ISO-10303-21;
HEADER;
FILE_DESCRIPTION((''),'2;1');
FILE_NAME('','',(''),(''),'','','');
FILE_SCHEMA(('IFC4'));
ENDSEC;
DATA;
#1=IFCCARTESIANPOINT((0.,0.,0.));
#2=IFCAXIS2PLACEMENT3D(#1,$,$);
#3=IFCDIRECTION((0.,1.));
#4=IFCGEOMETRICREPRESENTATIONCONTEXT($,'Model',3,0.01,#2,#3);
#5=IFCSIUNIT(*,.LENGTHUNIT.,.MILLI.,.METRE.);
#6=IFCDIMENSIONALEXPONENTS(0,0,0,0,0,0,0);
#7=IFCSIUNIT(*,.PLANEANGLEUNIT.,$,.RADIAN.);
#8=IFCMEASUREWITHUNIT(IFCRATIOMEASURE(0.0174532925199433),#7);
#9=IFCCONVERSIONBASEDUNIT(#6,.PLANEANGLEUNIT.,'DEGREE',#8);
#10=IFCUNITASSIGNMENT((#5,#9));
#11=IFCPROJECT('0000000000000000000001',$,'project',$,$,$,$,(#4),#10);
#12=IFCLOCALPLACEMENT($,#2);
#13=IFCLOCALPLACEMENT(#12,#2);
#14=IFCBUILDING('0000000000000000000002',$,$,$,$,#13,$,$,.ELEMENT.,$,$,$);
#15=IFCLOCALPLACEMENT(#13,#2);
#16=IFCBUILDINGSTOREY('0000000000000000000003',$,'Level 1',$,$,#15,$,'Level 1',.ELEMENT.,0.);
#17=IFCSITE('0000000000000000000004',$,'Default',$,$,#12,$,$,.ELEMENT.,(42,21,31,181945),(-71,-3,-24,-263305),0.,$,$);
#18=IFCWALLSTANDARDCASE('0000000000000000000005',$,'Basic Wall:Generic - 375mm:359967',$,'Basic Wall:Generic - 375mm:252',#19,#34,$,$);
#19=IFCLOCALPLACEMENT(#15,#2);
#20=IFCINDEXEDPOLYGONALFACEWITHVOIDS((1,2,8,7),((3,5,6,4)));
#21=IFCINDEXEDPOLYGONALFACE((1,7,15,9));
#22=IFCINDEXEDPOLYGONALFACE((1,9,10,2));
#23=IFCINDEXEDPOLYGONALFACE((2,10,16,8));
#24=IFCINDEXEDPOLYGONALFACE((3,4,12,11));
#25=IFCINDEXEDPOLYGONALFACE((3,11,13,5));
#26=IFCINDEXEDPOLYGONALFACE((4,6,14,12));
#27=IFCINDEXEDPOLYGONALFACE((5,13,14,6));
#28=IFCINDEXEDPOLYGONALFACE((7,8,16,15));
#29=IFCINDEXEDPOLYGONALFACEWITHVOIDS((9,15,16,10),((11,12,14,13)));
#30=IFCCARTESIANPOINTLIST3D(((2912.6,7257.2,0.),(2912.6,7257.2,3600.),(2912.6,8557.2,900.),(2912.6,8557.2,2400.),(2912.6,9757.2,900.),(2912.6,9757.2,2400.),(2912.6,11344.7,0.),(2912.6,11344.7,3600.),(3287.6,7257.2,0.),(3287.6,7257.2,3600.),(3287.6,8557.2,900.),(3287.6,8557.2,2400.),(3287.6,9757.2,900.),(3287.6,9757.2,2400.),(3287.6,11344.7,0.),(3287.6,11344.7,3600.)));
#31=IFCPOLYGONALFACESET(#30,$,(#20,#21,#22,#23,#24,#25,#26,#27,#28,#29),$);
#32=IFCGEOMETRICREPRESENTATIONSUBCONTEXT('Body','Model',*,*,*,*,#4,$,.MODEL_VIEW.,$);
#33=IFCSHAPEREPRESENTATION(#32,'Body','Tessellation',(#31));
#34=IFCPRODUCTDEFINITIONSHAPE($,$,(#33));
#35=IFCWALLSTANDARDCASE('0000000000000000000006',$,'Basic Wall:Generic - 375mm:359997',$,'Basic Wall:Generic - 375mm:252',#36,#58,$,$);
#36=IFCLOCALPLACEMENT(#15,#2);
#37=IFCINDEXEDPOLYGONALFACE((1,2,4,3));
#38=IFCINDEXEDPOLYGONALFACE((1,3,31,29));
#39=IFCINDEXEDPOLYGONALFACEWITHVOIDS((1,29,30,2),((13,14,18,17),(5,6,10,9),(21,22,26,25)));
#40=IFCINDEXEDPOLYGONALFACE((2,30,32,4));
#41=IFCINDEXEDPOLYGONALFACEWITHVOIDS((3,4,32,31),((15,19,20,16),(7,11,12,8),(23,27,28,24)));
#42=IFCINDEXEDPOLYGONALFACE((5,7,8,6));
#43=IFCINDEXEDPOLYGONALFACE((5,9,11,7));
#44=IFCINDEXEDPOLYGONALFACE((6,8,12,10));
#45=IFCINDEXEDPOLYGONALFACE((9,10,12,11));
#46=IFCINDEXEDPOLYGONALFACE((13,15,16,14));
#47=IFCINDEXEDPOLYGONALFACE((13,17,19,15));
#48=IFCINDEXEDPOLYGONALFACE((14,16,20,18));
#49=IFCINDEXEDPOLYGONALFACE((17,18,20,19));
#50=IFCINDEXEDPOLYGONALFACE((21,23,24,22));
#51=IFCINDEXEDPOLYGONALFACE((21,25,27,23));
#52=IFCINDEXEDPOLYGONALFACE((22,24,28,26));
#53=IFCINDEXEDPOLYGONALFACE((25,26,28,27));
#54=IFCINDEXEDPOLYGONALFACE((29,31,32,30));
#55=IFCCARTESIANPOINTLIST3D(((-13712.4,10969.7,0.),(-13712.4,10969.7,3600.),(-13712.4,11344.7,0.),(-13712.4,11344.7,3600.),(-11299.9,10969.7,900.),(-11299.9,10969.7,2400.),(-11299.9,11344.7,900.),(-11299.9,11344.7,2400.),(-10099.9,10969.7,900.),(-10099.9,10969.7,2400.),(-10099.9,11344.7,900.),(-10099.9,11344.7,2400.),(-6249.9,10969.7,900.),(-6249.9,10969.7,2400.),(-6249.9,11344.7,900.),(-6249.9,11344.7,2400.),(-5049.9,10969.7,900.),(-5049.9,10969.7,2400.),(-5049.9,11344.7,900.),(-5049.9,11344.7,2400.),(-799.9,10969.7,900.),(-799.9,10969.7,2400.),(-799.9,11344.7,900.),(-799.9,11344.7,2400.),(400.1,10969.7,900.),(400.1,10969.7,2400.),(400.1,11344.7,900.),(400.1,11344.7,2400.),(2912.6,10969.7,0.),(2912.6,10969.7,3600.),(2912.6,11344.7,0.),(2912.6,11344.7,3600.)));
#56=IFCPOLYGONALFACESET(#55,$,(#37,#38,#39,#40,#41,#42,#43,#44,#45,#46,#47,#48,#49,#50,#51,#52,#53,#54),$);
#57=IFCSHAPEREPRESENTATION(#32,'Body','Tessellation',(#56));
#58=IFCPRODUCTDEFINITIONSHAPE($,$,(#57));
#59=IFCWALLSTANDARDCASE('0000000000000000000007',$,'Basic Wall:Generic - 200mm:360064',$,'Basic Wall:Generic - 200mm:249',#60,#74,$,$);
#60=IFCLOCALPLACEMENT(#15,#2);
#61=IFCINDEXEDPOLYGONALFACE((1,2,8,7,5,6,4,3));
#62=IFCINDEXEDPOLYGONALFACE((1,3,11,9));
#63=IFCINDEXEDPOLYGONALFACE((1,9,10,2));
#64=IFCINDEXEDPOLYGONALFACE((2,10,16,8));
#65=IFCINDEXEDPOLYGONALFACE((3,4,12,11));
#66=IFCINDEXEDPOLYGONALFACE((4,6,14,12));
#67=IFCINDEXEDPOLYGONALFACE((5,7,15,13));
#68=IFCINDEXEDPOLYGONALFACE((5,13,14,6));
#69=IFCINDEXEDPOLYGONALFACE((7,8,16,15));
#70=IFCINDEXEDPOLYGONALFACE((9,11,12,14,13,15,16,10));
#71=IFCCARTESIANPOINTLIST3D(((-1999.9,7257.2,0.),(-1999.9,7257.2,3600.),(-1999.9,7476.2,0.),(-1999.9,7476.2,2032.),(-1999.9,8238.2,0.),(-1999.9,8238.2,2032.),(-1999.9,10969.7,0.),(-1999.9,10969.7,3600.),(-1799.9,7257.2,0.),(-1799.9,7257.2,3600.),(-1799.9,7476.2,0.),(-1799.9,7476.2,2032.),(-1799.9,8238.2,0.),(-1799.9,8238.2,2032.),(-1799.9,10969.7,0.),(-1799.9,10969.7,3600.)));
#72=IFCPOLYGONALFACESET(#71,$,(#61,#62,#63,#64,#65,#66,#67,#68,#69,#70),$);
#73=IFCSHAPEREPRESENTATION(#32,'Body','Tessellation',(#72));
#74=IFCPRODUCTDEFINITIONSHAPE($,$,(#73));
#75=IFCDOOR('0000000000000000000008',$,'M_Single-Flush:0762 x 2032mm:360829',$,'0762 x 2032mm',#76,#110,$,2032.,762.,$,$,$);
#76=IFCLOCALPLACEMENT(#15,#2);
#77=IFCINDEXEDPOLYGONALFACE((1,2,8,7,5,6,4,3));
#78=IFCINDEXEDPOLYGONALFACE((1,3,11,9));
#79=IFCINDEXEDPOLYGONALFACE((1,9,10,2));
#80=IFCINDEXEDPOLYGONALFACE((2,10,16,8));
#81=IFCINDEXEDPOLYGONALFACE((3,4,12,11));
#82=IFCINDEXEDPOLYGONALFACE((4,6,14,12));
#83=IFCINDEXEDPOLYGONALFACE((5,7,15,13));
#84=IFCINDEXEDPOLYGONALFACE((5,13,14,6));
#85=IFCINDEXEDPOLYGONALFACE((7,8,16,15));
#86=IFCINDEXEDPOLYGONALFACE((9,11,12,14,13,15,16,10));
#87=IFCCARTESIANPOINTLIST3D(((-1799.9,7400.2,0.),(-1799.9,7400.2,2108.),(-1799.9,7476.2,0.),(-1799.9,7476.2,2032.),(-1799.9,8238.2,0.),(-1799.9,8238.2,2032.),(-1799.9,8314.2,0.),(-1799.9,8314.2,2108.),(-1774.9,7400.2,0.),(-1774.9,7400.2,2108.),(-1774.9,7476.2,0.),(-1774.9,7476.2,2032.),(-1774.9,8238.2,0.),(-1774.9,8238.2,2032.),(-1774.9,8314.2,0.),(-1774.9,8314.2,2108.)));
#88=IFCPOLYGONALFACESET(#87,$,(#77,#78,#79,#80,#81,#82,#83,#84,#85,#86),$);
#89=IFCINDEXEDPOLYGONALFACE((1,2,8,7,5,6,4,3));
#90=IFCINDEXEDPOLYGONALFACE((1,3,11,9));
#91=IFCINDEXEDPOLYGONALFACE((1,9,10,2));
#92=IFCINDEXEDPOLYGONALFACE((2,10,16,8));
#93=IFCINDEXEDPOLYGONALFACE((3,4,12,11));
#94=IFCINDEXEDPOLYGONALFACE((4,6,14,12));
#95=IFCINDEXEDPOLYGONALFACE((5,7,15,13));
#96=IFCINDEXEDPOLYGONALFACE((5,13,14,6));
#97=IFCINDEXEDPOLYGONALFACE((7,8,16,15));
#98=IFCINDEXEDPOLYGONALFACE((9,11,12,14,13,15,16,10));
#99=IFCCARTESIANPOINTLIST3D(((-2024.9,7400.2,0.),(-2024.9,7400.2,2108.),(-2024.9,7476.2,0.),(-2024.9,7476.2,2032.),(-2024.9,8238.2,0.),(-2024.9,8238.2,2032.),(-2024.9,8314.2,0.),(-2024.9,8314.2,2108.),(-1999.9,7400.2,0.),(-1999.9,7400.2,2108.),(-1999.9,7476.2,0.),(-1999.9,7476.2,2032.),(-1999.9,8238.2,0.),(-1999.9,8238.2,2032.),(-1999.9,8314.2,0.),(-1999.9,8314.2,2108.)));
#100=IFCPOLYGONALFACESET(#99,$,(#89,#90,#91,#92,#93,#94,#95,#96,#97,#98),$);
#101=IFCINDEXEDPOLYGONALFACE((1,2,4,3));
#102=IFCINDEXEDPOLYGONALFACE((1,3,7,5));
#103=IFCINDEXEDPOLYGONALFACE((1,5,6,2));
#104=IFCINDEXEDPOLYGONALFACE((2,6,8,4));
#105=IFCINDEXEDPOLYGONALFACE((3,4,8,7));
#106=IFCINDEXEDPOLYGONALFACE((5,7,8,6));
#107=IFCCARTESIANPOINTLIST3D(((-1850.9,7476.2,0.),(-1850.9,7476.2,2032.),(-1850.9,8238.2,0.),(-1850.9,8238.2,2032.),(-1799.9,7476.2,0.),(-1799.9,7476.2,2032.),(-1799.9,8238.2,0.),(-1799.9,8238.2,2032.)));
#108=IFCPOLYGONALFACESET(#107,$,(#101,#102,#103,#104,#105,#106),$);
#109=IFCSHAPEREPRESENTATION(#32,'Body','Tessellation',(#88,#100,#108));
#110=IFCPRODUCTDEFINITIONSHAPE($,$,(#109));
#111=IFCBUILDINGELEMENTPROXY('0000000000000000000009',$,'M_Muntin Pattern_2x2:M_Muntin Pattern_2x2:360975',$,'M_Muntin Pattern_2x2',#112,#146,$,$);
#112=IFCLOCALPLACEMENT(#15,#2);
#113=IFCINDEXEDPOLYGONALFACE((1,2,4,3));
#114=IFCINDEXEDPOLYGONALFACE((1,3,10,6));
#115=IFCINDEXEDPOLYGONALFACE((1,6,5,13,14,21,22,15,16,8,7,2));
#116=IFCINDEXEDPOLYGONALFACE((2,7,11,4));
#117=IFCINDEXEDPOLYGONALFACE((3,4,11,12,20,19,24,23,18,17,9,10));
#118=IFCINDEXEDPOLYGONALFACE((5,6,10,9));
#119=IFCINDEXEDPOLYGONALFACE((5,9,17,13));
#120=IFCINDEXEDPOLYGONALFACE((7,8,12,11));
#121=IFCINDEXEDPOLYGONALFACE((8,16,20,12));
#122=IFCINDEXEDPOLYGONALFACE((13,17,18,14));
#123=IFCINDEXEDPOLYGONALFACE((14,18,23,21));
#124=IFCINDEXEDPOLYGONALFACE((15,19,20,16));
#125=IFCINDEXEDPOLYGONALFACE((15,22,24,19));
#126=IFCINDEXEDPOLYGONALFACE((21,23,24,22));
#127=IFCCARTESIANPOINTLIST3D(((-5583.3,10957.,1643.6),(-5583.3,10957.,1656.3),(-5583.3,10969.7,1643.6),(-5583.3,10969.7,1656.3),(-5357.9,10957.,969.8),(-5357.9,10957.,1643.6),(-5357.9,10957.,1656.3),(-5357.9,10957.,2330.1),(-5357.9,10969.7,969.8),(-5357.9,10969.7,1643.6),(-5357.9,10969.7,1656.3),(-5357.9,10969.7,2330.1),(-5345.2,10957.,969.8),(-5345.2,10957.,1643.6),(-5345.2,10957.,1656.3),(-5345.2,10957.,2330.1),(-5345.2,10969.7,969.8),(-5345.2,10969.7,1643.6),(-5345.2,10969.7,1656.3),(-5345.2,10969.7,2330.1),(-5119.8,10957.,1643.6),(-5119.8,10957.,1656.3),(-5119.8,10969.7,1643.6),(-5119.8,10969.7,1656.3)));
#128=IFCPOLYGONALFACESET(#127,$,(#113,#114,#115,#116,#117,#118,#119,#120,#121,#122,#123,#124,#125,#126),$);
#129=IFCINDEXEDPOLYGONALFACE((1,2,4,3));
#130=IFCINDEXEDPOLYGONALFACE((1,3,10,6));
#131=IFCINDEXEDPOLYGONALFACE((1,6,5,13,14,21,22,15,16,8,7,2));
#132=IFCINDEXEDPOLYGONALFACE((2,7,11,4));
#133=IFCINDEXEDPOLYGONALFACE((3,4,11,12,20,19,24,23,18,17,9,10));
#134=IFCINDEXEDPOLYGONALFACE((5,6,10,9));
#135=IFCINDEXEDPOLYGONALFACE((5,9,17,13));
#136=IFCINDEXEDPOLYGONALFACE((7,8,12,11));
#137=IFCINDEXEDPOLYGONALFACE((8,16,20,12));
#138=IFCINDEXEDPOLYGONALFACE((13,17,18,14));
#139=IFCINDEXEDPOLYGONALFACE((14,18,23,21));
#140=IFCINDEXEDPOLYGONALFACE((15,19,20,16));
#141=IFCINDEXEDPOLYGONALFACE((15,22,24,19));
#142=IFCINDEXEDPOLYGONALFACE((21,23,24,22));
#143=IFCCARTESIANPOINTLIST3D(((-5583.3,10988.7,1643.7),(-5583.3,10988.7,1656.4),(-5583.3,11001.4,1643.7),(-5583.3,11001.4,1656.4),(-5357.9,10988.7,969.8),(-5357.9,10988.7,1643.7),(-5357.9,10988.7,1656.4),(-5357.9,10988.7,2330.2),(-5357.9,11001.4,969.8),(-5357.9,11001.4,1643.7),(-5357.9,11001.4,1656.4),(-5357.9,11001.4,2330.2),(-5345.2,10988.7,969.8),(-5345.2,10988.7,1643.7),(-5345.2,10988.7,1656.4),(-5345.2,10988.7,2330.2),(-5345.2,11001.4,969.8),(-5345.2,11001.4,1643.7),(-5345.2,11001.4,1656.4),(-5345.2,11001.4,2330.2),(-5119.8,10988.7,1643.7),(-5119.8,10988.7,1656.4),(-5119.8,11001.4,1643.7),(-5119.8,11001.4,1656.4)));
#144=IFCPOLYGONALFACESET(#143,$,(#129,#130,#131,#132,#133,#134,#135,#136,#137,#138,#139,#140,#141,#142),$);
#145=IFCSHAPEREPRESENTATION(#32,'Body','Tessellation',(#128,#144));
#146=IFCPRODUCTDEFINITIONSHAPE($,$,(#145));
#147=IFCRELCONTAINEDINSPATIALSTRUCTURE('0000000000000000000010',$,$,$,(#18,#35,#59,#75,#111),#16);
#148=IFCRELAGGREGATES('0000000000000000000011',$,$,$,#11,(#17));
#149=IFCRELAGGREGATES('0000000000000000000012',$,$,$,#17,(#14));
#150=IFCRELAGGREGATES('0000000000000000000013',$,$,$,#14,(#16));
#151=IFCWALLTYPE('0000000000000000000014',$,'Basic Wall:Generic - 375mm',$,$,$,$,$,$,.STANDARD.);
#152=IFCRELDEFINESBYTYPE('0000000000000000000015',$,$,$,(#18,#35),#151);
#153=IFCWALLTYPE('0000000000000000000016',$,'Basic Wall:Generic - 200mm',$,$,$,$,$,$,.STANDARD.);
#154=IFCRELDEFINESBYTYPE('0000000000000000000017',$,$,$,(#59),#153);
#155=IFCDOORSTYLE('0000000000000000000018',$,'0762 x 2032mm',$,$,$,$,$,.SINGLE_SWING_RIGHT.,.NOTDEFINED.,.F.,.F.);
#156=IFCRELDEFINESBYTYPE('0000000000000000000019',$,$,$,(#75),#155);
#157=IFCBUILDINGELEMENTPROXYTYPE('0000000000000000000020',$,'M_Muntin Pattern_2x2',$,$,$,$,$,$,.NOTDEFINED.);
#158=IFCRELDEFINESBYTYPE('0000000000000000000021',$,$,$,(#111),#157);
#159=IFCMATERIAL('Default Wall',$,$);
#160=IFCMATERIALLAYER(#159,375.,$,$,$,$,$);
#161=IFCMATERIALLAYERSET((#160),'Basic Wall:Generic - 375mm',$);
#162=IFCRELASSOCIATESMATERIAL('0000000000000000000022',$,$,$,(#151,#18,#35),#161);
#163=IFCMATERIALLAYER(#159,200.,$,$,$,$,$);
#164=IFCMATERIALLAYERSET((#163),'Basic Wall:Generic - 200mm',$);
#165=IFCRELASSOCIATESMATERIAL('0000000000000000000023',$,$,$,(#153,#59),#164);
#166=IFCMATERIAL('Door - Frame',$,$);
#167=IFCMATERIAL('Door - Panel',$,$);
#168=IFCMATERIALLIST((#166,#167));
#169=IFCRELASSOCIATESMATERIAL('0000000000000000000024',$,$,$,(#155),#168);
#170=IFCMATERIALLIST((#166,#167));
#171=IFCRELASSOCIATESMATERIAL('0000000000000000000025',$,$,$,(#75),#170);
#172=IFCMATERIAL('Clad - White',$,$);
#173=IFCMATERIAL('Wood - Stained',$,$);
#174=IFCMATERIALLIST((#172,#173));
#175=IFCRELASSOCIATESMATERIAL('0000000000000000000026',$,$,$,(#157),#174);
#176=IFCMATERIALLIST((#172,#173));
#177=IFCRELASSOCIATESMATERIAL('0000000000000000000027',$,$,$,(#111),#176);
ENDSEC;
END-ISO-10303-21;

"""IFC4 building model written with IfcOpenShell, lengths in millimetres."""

from ifc_helpers import new_model, entity, si_unit, converted_unit, direction, frame, frame_2d, origin, place, context, subcontext, project, spatial, polyline, rectangle, outline, extrude, clip, bounded_halfspace, source, transform, mapped, material, material_list, layer, layer_set, layer_usage, type_object, type_shapes, element, fill, save


model = new_model("IFC4")

# Units and contexts
model_context = context("Model", 3, precision=0.01, world=origin(), true_north=direction((0.0, 1.0)))
body_context = subcontext(model_context, "Body", "Model", "MODEL_VIEW")
ifc_project = project(units=[si_unit("LENGTHUNIT", "METRE", prefix="MILLI"), converted_unit("PLANEANGLEUNIT", "DEGREE", entity("IfcRatioMeasure", 0.0174532925199433), si_unit("PLANEANGLEUNIT", "RADIAN"), dimensions=[0, 0, 0, 0, 0, 0, 0])], contexts=[model_context])

# Site, building, storey
site_placement = place(None, origin())
site = spatial("IfcSite", under=ifc_project, at=site_placement, Name="Default", CompositionType="ELEMENT", RefLatitude=(42, 21, 31, 181945), RefLongitude=(-71, -3, -24, -263305), RefElevation=0.0)
building_placement = place(site_placement, origin())
building = spatial("IfcBuilding", under=site, at=building_placement, CompositionType="ELEMENT")
storey_placement = place(building_placement, origin())
storey = spatial("IfcBuildingStorey", under=building, at=storey_placement, Name="Level 1", LongName="Level 1", CompositionType="ELEMENT", Elevation=0.0)

# Wall, opening
ifc_material_1 = material(Name="Default Wall")
ifc_layer_1 = layer(ifc_material_1, 375.0)
ifc_layer_set_1 = layer_set([ifc_layer_1], Name="Basic Wall:Generic - 375mm")
ifc_layer_usage_1 = layer_usage(ifc_layer_set_1, "AXIS2", "NEGATIVE", 187.5)
wall_type_1 = type_object("IfcWallType", Name="Basic Wall:Generic - 375mm", PredefinedType="STANDARD", material=ifc_layer_set_1)
wall_1_placement = place(storey_placement, frame((3100.1, 7257.2, 0.0), z_axis=(0.0, 0.0, 1.0), x_axis=(0.0, 1.0, 0.0)))
wall_1 = element("IfcWallStandardCase", 1, at=wall_1_placement, inside=storey, type_object=wall_type_1, material=ifc_layer_usage_1, Name="Basic Wall:Generic - 375mm:359967", ObjectType="Basic Wall:Generic - 375mm:252", context=body_context, shape_type="Clipping", body=[
    clip(extrude(rectangle(XDim=4087.5, YDim=375.0, at=frame_2d((2043.8, 0.0), x_axis=(-1.0, 0.0))), origin(), (0.0, 0.0, 1.0), 3600.0), bounded_halfspace(frame((0.0, -187.5, 3600.0), z_axis=(0.0, 0.0, -1.0), x_axis=(0.0, -1.0, 0.0)), True, frame((0.0, -187.5, 3600.0)), polyline([(0.0, 0.0), (4087.5, 0.0), (4087.5, 375.0), (3712.5, 375.0), (0.0, 375.0), (0.0, 0.0)]))),
])
opening_1_placement = place(wall_1_placement, frame((1300.0, -187.5, 900.0)))
element("IfcOpeningElement", 2, at=opening_1_placement, cuts=wall_1, ObjectType="Opening", context=body_context, shape_type="SweptSolid", body=[
    extrude(rectangle(XDim=1500.0, YDim=1200.0, at=frame_2d((750.0, 600.0), x_axis=(-1.0, 0.0))), frame((0.0, 0.0, 0.0), z_axis=(0.0, 1.0, 0.0), x_axis=(0.0, 0.0, 1.0)), (0.0, 0.0, 1.0), 375.0),
])

# Wall, openings
ifc_layer_usage_2 = layer_usage(ifc_layer_set_1, "AXIS2", "NEGATIVE", 187.5)
wall_2_placement = place(storey_placement, frame((2912.6, 11157.2, 0.0), z_axis=(0.0, 0.0, 1.0), x_axis=(-1.0, 0.0, 0.0)))
wall_2 = element("IfcWallStandardCase", 3, at=wall_2_placement, inside=storey, type_object=wall_type_1, material=ifc_layer_usage_2, Name="Basic Wall:Generic - 375mm:359997", ObjectType="Basic Wall:Generic - 375mm:252", context=body_context, shape_type="Clipping", body=[
    clip(extrude(rectangle(XDim=16625.0, YDim=375.0, at=frame_2d((8312.5, 0.0), x_axis=(-1.0, 0.0))), origin(), (0.0, 0.0, 1.0), 3600.0), bounded_halfspace(frame((0.0, -187.5, 3600.0), z_axis=(0.0, 0.0, -1.0), x_axis=(-1.0, 0.0, 0.0)), True, frame((0.0, -187.5, 3600.0)), polyline([(0.0, 0.0), (16625.0, 0.0), (16625.0, 375.0), (12412.5, 375.0), (12212.5, 375.0), (4912.5, 375.0), (4712.5, 375.0), (0.0, 375.0), (0.0, 0.0)]))),
])
opening_2_placement = place(wall_2_placement, frame((7962.5, -187.5, 900.0)))
element("IfcOpeningElement", 4, at=opening_2_placement, cuts=wall_2, ObjectType="Opening", context=body_context, shape_type="SweptSolid", body=[
    extrude(rectangle(XDim=1500.0, YDim=1200.0, at=frame_2d((750.0, 600.0), x_axis=(-1.0, 0.0))), frame((0.0, 0.0, 0.0), z_axis=(0.0, 1.0, 0.0), x_axis=(0.0, 0.0, 1.0)), (0.0, 0.0, 1.0), 375.0),
])
opening_3_placement = place(wall_2_placement, frame((2512.5, -187.5, 900.0)))
element("IfcOpeningElement", 5, at=opening_3_placement, cuts=wall_2, ObjectType="Opening", context=body_context, shape_type="SweptSolid", body=[
    extrude(rectangle(XDim=1500.0, YDim=1200.0, at=frame_2d((750.0, 600.0), x_axis=(-1.0, 0.0))), frame((0.0, 0.0, 0.0), z_axis=(0.0, 1.0, 0.0), x_axis=(0.0, 0.0, 1.0)), (0.0, 0.0, 1.0), 375.0),
])
opening_4_placement = place(wall_2_placement, frame((13012.5, -187.5, 900.0)))
element("IfcOpeningElement", 6, at=opening_4_placement, cuts=wall_2, ObjectType="Opening", context=body_context, shape_type="SweptSolid", body=[
    extrude(rectangle(XDim=1500.0, YDim=1200.0, at=frame_2d((750.0, 600.0), x_axis=(-1.0, 0.0))), frame((0.0, 0.0, 0.0), z_axis=(0.0, 1.0, 0.0), x_axis=(0.0, 0.0, 1.0)), (0.0, 0.0, 1.0), 375.0),
])

# Wall, opening, door
ifc_layer_2 = layer(ifc_material_1, 200.0)
ifc_layer_set_2 = layer_set([ifc_layer_2], Name="Basic Wall:Generic - 200mm")
ifc_layer_usage_3 = layer_usage(ifc_layer_set_2, "AXIS2", "NEGATIVE", 100.0)
wall_type_2 = type_object("IfcWallType", Name="Basic Wall:Generic - 200mm", PredefinedType="STANDARD", material=ifc_layer_set_2)
wall_3_placement = place(storey_placement, frame((-1899.9, 10969.7, 0.0), z_axis=(0.0, 0.0, 1.0), x_axis=(0.0, -1.0, 0.0)))
wall_3 = element("IfcWallStandardCase", 7, at=wall_3_placement, inside=storey, type_object=wall_type_2, material=ifc_layer_usage_3, Name="Basic Wall:Generic - 200mm:360064", ObjectType="Basic Wall:Generic - 200mm:249", context=body_context, shape_type="Clipping", body=[
    clip(extrude(rectangle(XDim=3712.5, YDim=200.0, at=frame_2d((1856.3, 0.0), x_axis=(-1.0, 0.0))), origin(), (0.0, 0.0, 1.0), 3600.0), bounded_halfspace(frame((0.0, -100.0, 3600.0), z_axis=(0.0, 0.0, -1.0), x_axis=(0.0, 1.0, 0.0)), True, frame((0.0, -100.0, 3600.0)), polyline([(0.0, 0.0), (3712.5, 0.0), (3712.5, 200.0), (0.0, 200.0), (0.0, 0.0)]))),
])
opening_5_placement = place(wall_3_placement, frame((2731.5, -100.0, 0.0)))
opening_5 = element("IfcOpeningElement", 8, at=opening_5_placement, cuts=wall_3, ObjectType="Opening", context=body_context, shape_type="SweptSolid", body=[
    extrude(rectangle(XDim=762.0, YDim=2032.0, at=frame_2d((1016.0, 381.0), x_axis=(0.0, 1.0))), frame((0.0, 0.0, 0.0), z_axis=(0.0, 1.0, 0.0), x_axis=(0.0, 0.0, 1.0)), (0.0, 0.0, 1.0), 200.0),
])
ifc_material_2 = material(Name="Door - Frame")
ifc_material_3 = material(Name="Door - Panel")
ifc_material_list_1 = material_list([ifc_material_2, ifc_material_3])
ifc_material_list_2 = material_list([ifc_material_2, ifc_material_3])
door_style = type_object("IfcDoorStyle", Name="0762 x 2032mm", ConstructionType="NOTDEFINED", OperationType="SINGLE_SWING_RIGHT", ParameterTakesPrecedence=False, Sizeable=False, material=ifc_material_list_2)
shared_shape_1 = source(origin(), body_context, "Body", "SweptSolid", [
    extrude(outline(polyline([(-457.0, -1073.0), (457.0, -1073.0), (457.0, 1035.0), (381.0, 1035.0), (381.0, -997.0), (-381.0, -997.0), (-381.0, 1035.0), (-457.0, 1035.0), (-457.0, -1073.0)])), frame((381.0, 200.0, 1035.0), z_axis=(0.0, 1.0, 0.0), x_axis=(1.0, 0.0, 0.0)), (0.0, 0.0, 1.0), 25.0),
    extrude(outline(polyline([(-1073.0, -457.0), (1035.0, -457.0), (1035.0, -381.0), (-997.0, -381.0), (-997.0, 381.0), (1035.0, 381.0), (1035.0, 457.0), (-1073.0, 457.0), (-1073.0, -457.0)])), frame((381.0, -25.0, 1035.0), z_axis=(0.0, 1.0, 0.0), x_axis=(0.0, 0.0, -1.0)), (0.0, 0.0, 1.0), 25.0),
    extrude(rectangle(XDim=51.0, YDim=762.0, at=frame_2d((0.0, 0.0), x_axis=(1.0, 0.0))), frame((381.0, 174.5, 0.0), z_axis=(0.0, 0.0, 1.0), x_axis=(0.0, 1.0, 0.0)), (0.0, 0.0, 1.0), 2032.0),
])
type_shapes(door_style, [shared_shape_1])
door_placement = place(opening_5_placement, origin())
door = element("IfcDoor", 9, at=door_placement, inside=storey, type_object=door_style, material=ifc_material_list_1, Name="M_Single-Flush:0762 x 2032mm:360829", ObjectType="0762 x 2032mm", OverallHeight=2032.0, OverallWidth=762.0, context=body_context, shape_type="MappedRepresentation", body=[
    mapped(shared_shape_1, transform((0.0, 0.0, 0.0), scale=1.0)),
])
fill(opening_5, door)

# Building element proxy
ifc_material_4 = material(Name="Clad - White")
ifc_material_5 = material(Name="Wood - Stained")
ifc_material_list_3 = material_list([ifc_material_4, ifc_material_5])
ifc_material_list_4 = material_list([ifc_material_4, ifc_material_5])
building_element_proxy_type_1 = type_object("IfcBuildingElementProxyType", Name="M_Muntin Pattern_2x2", PredefinedType="NOTDEFINED", material=ifc_material_list_4)
shared_shape_2 = source(origin(), body_context, "Body", "SweptSolid", [
    extrude(outline(polyline([(6.4, -6.4), (680.1, -6.4), (680.1, 6.3), (6.4, 6.3), (6.4, 231.7), (-6.3, 231.7), (-6.3, 6.3), (-680.2, 6.3), (-680.2, -6.4), (-6.3, -6.4), (-6.3, -231.7), (6.4, -231.7), (6.4, -6.4)])), frame((0.0, 9.5, 680.1), z_axis=(0.0, 1.0, 0.0), x_axis=(0.0, 0.0, 1.0)), (0.0, 0.0, 1.0), 12.7),
    extrude(outline(polyline([(6.4, -6.4), (680.2, -6.4), (680.2, 6.3), (6.4, 6.3), (6.4, 231.7), (-6.3, 231.7), (-6.3, 6.3), (-680.2, 6.3), (-680.2, -6.4), (-6.3, -6.4), (-6.3, -231.7), (6.4, -231.7), (6.4, -6.4)])), frame((0.0, -22.2, 680.2), z_axis=(0.0, 1.0, 0.0), x_axis=(0.0, 0.0, 1.0)), (0.0, 0.0, 1.0), 12.7),
])
type_shapes(building_element_proxy_type_1, [shared_shape_2])
proxy_1_placement = place(storey_placement, frame((-5351.5, 10979.2, 969.8), z_axis=(0.0, 0.0, 1.0), x_axis=(-1.0, 0.0, 0.0)))
element("IfcBuildingElementProxy", 10, at=proxy_1_placement, inside=storey, type_object=building_element_proxy_type_1, material=ifc_material_list_3, Name="M_Muntin Pattern_2x2:M_Muntin Pattern_2x2:360975", ObjectType="M_Muntin Pattern_2x2", context=body_context, shape_type="MappedRepresentation", body=[
    mapped(shared_shape_2, transform((0.0, 0.0, 0.0), scale=1.0)),
])

save(model, "model.ifc")
